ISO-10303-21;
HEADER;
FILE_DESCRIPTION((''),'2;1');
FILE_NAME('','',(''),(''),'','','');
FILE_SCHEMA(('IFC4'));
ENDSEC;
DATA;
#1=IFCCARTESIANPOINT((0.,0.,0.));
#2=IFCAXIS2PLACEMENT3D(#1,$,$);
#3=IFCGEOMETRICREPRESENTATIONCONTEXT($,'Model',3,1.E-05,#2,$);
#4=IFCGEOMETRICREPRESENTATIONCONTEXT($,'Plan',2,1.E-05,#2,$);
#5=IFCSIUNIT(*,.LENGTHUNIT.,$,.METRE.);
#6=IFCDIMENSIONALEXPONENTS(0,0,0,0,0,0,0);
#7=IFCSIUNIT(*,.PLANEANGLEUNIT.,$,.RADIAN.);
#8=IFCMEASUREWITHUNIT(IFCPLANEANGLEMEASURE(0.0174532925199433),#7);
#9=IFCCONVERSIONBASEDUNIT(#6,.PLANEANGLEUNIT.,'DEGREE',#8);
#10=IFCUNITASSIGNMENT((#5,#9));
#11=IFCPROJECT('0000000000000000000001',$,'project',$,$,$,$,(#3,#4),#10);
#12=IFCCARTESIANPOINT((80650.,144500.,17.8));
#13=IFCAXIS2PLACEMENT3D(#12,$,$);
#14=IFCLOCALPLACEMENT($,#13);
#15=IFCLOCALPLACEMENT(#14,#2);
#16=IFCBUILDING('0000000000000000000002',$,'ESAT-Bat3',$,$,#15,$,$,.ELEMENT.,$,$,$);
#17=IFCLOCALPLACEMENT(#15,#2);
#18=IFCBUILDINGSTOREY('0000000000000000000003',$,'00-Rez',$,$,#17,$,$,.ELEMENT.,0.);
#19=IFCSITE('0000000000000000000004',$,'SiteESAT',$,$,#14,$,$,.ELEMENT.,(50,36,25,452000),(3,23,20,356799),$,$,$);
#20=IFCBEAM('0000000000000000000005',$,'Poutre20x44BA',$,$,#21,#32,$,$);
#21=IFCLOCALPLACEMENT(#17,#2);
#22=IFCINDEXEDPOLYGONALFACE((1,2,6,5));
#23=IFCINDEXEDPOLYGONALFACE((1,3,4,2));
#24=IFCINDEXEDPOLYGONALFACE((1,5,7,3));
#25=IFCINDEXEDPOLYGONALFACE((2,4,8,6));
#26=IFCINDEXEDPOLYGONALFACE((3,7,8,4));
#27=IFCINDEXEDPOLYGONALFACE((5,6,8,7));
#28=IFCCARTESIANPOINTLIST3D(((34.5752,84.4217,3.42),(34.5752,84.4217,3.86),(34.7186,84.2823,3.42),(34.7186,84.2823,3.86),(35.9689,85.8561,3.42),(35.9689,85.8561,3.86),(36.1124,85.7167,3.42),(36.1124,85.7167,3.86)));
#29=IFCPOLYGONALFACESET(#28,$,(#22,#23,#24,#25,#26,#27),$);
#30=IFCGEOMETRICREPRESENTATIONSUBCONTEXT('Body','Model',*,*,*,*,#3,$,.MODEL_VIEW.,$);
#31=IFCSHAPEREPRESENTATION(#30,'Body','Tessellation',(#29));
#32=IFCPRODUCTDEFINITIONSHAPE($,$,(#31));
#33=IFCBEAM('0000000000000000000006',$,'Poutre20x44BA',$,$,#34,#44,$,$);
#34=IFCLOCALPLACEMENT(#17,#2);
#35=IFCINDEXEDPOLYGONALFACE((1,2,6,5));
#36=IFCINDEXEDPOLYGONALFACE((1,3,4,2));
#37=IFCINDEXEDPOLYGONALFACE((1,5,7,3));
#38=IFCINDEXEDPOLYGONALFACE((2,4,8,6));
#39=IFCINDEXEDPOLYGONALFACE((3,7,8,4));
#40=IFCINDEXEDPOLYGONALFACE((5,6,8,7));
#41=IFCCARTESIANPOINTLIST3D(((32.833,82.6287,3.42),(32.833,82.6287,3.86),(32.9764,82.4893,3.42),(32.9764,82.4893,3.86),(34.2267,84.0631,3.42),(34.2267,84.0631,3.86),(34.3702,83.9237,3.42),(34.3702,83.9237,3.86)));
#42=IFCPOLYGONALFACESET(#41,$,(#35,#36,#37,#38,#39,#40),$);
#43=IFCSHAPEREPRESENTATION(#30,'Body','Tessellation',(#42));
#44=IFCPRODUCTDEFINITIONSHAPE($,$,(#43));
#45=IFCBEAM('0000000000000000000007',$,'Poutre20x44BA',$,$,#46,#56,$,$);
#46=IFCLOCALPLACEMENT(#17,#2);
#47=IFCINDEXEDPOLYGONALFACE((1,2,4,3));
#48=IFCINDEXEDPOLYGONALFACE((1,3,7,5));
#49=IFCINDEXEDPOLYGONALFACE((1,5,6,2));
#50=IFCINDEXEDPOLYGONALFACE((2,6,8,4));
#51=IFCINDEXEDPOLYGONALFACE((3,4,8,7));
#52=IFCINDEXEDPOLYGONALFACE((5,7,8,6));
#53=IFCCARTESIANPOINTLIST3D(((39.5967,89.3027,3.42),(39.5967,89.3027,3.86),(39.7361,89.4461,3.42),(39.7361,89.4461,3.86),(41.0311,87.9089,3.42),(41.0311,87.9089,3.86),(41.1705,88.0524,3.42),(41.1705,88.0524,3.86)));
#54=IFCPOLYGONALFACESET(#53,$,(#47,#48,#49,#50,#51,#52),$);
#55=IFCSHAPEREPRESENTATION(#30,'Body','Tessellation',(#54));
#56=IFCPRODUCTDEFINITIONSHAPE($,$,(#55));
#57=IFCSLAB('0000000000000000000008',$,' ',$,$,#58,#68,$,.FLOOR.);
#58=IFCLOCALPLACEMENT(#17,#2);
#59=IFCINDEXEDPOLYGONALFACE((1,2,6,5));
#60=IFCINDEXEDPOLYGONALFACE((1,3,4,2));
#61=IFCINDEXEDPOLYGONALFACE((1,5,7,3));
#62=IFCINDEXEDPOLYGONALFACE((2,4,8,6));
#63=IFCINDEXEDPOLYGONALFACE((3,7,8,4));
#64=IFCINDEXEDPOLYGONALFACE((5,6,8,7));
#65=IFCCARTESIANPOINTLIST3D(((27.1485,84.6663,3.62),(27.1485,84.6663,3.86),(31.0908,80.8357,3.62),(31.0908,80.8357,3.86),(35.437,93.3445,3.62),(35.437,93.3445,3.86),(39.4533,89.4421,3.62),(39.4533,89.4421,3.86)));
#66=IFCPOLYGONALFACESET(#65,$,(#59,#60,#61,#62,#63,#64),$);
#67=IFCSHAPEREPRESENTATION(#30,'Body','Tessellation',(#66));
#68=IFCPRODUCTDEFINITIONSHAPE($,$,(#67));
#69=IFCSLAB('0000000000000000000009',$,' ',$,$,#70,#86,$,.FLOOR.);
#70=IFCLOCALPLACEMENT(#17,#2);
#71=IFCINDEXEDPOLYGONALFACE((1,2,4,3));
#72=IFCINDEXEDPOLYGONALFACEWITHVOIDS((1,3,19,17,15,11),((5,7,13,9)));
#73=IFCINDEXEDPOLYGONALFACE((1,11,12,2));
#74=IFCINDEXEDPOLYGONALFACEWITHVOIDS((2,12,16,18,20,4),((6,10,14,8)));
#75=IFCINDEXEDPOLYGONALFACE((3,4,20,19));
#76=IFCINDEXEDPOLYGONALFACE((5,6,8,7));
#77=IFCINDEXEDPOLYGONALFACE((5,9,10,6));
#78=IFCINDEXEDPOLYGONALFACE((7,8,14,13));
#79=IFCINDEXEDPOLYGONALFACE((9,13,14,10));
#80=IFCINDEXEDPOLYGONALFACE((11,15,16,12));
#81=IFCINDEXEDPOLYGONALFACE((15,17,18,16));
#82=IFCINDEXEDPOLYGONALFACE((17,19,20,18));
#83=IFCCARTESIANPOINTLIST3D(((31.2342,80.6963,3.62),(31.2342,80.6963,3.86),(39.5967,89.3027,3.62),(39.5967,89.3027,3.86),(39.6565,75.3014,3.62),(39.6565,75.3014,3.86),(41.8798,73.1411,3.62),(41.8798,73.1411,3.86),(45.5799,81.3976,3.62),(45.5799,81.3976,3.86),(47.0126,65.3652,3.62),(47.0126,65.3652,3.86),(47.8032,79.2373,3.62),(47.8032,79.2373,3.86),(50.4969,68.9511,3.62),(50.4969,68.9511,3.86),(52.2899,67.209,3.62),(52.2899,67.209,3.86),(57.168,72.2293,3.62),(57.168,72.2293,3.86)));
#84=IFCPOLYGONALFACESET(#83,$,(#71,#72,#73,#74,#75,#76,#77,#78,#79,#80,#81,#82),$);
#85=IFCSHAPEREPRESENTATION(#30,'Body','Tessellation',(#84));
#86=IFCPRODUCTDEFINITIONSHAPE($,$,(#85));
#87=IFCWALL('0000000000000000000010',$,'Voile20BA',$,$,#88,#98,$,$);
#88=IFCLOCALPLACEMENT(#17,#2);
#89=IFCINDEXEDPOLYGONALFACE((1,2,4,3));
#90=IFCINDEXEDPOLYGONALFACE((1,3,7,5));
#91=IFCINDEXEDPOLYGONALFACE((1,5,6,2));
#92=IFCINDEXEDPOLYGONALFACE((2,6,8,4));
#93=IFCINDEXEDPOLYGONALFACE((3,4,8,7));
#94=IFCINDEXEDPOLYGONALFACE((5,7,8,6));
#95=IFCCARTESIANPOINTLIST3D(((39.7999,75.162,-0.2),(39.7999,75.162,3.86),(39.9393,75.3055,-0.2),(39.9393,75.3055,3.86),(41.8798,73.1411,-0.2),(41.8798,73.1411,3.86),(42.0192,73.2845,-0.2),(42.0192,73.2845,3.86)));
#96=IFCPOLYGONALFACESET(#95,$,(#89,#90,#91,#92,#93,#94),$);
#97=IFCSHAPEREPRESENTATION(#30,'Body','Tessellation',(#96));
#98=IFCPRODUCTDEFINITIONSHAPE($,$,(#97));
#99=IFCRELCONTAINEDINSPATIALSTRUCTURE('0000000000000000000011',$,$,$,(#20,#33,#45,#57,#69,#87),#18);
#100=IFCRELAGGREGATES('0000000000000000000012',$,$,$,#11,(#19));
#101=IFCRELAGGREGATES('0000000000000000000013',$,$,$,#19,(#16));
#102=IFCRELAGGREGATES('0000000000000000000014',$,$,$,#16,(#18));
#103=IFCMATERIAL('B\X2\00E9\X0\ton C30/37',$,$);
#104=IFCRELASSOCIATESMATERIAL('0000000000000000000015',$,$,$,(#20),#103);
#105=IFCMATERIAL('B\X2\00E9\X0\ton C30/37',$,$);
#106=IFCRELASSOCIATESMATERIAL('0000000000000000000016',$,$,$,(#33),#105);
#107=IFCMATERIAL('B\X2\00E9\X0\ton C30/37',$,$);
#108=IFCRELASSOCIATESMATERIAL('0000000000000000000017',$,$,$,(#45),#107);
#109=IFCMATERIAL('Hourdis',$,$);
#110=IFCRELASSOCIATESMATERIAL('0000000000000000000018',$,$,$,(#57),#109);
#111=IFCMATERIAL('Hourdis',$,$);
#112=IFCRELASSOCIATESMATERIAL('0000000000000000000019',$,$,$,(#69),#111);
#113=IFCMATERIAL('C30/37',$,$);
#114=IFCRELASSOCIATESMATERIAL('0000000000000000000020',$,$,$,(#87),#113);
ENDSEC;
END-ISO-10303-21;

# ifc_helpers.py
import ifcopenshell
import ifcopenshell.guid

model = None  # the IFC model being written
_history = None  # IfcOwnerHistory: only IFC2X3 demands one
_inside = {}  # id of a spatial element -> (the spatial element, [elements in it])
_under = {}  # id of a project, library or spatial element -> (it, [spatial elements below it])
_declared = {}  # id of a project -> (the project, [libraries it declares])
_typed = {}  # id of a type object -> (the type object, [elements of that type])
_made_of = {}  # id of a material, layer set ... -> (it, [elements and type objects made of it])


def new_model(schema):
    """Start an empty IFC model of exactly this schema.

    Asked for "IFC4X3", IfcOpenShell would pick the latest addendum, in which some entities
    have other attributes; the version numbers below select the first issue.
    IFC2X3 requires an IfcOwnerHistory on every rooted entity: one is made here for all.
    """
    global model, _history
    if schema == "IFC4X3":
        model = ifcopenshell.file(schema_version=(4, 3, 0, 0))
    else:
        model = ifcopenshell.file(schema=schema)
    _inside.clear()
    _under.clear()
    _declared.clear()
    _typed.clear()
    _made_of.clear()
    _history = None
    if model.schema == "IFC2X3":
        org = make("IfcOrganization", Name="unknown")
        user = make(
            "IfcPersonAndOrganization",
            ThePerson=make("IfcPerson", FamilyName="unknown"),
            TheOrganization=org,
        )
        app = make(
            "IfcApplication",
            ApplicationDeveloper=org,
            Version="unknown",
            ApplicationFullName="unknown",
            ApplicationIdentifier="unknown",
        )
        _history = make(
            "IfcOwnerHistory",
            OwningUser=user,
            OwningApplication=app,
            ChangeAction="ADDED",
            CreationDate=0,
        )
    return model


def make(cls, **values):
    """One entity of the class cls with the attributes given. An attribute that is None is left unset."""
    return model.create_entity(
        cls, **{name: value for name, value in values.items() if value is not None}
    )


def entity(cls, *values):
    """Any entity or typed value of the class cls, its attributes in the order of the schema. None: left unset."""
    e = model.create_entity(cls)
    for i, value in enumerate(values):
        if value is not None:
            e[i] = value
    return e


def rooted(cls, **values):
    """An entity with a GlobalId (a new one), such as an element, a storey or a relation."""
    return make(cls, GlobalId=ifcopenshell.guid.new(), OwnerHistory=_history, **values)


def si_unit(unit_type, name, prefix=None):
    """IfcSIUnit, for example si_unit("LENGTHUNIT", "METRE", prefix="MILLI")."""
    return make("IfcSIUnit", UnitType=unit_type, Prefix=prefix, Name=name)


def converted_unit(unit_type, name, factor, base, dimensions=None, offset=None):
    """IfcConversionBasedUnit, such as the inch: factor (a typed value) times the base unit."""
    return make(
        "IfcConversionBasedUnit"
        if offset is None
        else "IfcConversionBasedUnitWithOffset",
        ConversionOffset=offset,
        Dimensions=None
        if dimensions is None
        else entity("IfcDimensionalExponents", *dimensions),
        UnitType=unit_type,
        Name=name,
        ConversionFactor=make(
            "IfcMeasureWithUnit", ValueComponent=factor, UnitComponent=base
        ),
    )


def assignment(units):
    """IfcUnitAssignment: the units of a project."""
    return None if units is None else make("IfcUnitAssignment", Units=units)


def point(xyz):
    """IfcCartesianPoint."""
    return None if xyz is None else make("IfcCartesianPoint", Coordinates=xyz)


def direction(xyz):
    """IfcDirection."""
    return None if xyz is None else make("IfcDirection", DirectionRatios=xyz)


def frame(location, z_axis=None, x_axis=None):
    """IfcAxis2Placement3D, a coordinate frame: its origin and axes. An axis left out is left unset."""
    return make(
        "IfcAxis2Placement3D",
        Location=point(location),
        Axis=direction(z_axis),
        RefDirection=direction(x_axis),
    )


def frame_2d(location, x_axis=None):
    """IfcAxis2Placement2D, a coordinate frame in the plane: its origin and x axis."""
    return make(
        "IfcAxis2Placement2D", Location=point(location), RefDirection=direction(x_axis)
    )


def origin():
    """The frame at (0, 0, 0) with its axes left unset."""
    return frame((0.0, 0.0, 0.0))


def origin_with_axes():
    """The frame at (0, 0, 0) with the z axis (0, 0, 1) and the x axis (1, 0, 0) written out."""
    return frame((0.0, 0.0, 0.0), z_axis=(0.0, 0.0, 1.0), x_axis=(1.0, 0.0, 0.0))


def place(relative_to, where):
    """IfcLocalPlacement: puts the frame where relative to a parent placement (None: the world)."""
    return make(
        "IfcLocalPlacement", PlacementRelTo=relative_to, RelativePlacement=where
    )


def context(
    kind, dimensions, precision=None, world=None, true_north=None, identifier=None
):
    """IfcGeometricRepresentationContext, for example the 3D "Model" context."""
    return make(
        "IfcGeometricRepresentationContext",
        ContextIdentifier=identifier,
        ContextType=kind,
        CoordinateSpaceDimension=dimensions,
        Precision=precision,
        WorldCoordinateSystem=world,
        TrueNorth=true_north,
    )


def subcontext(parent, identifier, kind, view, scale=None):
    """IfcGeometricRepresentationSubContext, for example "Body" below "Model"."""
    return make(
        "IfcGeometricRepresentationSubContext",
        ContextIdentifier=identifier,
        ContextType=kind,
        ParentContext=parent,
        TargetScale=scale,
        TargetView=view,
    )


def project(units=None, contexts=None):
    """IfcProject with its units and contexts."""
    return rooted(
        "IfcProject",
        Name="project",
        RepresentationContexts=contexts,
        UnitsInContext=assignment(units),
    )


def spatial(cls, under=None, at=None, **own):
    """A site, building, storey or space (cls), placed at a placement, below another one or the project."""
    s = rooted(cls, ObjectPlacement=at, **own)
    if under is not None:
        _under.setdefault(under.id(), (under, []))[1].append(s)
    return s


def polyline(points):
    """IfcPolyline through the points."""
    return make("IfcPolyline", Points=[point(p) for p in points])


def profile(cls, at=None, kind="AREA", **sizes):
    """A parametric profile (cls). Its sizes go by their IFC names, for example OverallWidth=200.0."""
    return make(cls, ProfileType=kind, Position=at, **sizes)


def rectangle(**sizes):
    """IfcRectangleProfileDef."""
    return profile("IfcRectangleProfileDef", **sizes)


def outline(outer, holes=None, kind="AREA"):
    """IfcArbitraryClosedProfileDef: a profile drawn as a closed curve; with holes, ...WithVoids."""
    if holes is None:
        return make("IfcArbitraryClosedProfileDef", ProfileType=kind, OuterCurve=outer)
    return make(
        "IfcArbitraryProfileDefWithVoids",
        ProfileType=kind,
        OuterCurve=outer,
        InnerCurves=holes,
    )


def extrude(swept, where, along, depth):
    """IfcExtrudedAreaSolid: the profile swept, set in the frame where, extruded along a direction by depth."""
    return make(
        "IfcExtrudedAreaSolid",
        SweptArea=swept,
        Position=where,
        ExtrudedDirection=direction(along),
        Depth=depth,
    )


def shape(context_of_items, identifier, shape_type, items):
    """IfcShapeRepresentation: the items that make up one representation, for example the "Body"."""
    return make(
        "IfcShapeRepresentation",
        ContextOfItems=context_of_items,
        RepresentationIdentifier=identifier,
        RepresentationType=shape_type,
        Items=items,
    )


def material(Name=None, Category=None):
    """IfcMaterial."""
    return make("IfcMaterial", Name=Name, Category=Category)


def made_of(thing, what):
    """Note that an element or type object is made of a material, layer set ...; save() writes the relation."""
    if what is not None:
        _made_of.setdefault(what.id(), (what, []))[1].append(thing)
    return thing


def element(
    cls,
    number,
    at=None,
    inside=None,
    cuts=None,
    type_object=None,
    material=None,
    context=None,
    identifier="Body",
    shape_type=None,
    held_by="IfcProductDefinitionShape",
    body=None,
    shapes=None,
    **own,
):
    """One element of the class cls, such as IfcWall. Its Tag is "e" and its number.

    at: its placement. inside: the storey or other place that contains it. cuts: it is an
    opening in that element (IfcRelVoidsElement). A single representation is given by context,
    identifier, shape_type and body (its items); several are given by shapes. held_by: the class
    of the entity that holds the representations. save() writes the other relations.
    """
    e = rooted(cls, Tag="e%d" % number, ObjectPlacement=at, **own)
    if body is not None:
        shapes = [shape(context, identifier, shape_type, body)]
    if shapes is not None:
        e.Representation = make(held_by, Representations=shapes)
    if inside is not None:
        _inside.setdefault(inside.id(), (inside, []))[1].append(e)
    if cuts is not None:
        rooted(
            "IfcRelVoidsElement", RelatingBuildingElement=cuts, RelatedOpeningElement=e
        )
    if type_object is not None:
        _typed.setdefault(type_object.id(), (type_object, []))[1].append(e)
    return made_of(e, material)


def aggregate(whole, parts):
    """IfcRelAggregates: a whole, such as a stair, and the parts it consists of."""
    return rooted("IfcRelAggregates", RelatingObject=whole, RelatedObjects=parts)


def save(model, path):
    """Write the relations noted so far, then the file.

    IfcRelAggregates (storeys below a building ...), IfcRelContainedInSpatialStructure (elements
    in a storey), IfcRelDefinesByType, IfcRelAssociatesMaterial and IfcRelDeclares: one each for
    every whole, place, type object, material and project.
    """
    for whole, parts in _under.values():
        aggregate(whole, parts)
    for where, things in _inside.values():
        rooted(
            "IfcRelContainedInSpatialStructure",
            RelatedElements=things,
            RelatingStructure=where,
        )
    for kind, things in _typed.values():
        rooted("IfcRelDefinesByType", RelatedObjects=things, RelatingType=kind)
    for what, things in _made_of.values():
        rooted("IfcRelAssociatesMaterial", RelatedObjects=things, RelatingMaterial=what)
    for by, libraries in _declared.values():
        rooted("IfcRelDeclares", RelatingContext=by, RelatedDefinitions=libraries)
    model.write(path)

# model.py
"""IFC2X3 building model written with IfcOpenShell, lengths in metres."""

from ifc_helpers import new_model, entity, si_unit, converted_unit, frame, frame_2d, origin, origin_with_axes, place, context, subcontext, project, spatial, polyline, rectangle, outline, extrude, material, element, save


model = new_model("IFC2X3")

# Units and contexts
model_context = context("Model", 3, precision=1e-05, world=origin())
plan_context = context("Plan", 2, precision=1e-05, world=origin())
body_context = subcontext(model_context, "Body", "Model", "MODEL_VIEW")
ifc_project = project(units=[si_unit("LENGTHUNIT", "METRE"), converted_unit("PLANEANGLEUNIT", "DEGREE", entity("IfcPlaneAngleMeasure", 0.0174532925199433), si_unit("PLANEANGLEUNIT", "RADIAN"), dimensions=[0, 0, 0, 0, 0, 0, 0])], contexts=[model_context, plan_context])

# Site, building, storey
site_placement = place(None, frame((80650.0, 144500.0, 17.8)))
site = spatial("IfcSite", under=ifc_project, at=site_placement, Name="SiteESAT", CompositionType="ELEMENT", RefLatitude=(50, 36, 25, 452000), RefLongitude=(3, 23, 20, 356799))
building_placement = place(site_placement, origin())
building = spatial("IfcBuilding", under=site, at=building_placement, Name="ESAT-Bat3", CompositionType="ELEMENT")
storey_placement = place(building_placement, origin())
storey = spatial("IfcBuildingStorey", under=building, at=storey_placement, Name="00-Rez", CompositionType="ELEMENT", Elevation=0.0)

# Beams
ifc_material_1 = material(Name="Béton C30/37")
beam_1_placement = place(storey_placement, frame((34.7186, 84.2823, 3.42), z_axis=(0.0, 0.0, 1.0), x_axis=(0.696872, 0.717196, 0.0)))
element("IfcBeam", 1, at=beam_1_placement, inside=storey, material=ifc_material_1, Name="Poutre20x44BA", context=body_context, shape_type="SweptSolid", body=[
    extrude(rectangle(XDim=0.2, YDim=0.44, at=frame_2d((0.1, 0.22), x_axis=(1.0, 0.0))), frame((0.0, 0.0, 0.0), z_axis=(1.0, 0.0, 0.0), x_axis=(0.0, 1.0, 0.0)), (0.0, 0.0, 1.0), 2.0),
])
ifc_material_2 = material(Name="Béton C30/37")
beam_2_placement = place(storey_placement, frame((32.9764, 82.4893, 3.42), z_axis=(0.0, 0.0, 1.0), x_axis=(0.696872, 0.717196, 0.0)))
element("IfcBeam", 2, at=beam_2_placement, inside=storey, material=ifc_material_2, Name="Poutre20x44BA", context=body_context, shape_type="SweptSolid", body=[
    extrude(rectangle(XDim=0.2, YDim=0.44, at=frame_2d((0.1, 0.22), x_axis=(1.0, 0.0))), frame((0.0, 0.0, 0.0), z_axis=(1.0, 0.0, 0.0), x_axis=(0.0, 1.0, 0.0)), (0.0, 0.0, 1.0), 2.0),
])
ifc_material_3 = material(Name="Béton C30/37")
beam_3_placement = place(storey_placement, frame((41.1705, 88.0524, 3.42), z_axis=(0.0, 0.0, 1.0), x_axis=(-0.717196, 0.696872, 0.0)))
element("IfcBeam", 3, at=beam_3_placement, inside=storey, material=ifc_material_3, Name="Poutre20x44BA", context=body_context, shape_type="SweptSolid", body=[
    extrude(rectangle(XDim=0.2, YDim=0.44, at=frame_2d((0.1, 0.22), x_axis=(1.0, 0.0))), frame((0.0, 0.0, 0.0), z_axis=(1.0, 0.0, 0.0), x_axis=(0.0, 1.0, 0.0)), (0.0, 0.0, 1.0), 2.0),
])

# Slabs
ifc_material_4 = material(Name="Hourdis")
slab_1_placement = place(storey_placement, frame((27.1485, 80.8357, 3.62)))
element("IfcSlab", 4, at=slab_1_placement, inside=storey, material=ifc_material_4, Name=" ", PredefinedType="FLOOR", context=body_context, shape_type="SweptSolid", body=[
    extrude(outline(polyline([(0.0, 3.8306), (3.9423, 0.0), (12.3047, 8.6063), (8.2884, 12.5088), (0.0, 3.8306)])), origin_with_axes(), (0.0, 0.0, 1.0), 0.24),
])
ifc_material_5 = material(Name="Hourdis")
slab_2_placement = place(storey_placement, frame((31.2342, 65.3652, 3.62)))
element("IfcSlab", 5, at=slab_2_placement, inside=storey, material=ifc_material_5, Name=" ", PredefinedType="FLOOR", context=body_context, shape_type="SweptSolid", body=[
    extrude(outline(polyline([(21.0557, 1.8438), (25.9338, 6.8642), (8.3625, 23.9375), (0.0, 15.3312), (15.7783, 0.0), (19.2627, 3.586), (21.0557, 1.8438)]), holes=[polyline([(14.3457, 16.0324), (16.569, 13.8721), (10.6456, 7.7759), (8.4223, 9.9362), (14.3457, 16.0324)])]), origin_with_axes(), (0.0, 0.0, 1.0), 0.24),
])

# Wall
ifc_material_6 = material(Name="C30/37")
wall_1_placement = place(storey_placement, frame((39.7999, 75.162, -0.2), z_axis=(0.0, 0.0, 1.0), x_axis=(0.717196, -0.696872, 0.0)))
element("IfcWall", 6, at=wall_1_placement, inside=storey, material=ifc_material_6, Name="Voile20BA", context=body_context, shape_type="SweptSolid", body=[
    extrude(rectangle(XDim=2.9, YDim=0.2, at=frame_2d((1.45, 0.1), x_axis=(1.0, 0.0))), origin_with_axes(), (0.0, 0.0, 1.0), 4.06),
])

save(model, "model.ifc")
